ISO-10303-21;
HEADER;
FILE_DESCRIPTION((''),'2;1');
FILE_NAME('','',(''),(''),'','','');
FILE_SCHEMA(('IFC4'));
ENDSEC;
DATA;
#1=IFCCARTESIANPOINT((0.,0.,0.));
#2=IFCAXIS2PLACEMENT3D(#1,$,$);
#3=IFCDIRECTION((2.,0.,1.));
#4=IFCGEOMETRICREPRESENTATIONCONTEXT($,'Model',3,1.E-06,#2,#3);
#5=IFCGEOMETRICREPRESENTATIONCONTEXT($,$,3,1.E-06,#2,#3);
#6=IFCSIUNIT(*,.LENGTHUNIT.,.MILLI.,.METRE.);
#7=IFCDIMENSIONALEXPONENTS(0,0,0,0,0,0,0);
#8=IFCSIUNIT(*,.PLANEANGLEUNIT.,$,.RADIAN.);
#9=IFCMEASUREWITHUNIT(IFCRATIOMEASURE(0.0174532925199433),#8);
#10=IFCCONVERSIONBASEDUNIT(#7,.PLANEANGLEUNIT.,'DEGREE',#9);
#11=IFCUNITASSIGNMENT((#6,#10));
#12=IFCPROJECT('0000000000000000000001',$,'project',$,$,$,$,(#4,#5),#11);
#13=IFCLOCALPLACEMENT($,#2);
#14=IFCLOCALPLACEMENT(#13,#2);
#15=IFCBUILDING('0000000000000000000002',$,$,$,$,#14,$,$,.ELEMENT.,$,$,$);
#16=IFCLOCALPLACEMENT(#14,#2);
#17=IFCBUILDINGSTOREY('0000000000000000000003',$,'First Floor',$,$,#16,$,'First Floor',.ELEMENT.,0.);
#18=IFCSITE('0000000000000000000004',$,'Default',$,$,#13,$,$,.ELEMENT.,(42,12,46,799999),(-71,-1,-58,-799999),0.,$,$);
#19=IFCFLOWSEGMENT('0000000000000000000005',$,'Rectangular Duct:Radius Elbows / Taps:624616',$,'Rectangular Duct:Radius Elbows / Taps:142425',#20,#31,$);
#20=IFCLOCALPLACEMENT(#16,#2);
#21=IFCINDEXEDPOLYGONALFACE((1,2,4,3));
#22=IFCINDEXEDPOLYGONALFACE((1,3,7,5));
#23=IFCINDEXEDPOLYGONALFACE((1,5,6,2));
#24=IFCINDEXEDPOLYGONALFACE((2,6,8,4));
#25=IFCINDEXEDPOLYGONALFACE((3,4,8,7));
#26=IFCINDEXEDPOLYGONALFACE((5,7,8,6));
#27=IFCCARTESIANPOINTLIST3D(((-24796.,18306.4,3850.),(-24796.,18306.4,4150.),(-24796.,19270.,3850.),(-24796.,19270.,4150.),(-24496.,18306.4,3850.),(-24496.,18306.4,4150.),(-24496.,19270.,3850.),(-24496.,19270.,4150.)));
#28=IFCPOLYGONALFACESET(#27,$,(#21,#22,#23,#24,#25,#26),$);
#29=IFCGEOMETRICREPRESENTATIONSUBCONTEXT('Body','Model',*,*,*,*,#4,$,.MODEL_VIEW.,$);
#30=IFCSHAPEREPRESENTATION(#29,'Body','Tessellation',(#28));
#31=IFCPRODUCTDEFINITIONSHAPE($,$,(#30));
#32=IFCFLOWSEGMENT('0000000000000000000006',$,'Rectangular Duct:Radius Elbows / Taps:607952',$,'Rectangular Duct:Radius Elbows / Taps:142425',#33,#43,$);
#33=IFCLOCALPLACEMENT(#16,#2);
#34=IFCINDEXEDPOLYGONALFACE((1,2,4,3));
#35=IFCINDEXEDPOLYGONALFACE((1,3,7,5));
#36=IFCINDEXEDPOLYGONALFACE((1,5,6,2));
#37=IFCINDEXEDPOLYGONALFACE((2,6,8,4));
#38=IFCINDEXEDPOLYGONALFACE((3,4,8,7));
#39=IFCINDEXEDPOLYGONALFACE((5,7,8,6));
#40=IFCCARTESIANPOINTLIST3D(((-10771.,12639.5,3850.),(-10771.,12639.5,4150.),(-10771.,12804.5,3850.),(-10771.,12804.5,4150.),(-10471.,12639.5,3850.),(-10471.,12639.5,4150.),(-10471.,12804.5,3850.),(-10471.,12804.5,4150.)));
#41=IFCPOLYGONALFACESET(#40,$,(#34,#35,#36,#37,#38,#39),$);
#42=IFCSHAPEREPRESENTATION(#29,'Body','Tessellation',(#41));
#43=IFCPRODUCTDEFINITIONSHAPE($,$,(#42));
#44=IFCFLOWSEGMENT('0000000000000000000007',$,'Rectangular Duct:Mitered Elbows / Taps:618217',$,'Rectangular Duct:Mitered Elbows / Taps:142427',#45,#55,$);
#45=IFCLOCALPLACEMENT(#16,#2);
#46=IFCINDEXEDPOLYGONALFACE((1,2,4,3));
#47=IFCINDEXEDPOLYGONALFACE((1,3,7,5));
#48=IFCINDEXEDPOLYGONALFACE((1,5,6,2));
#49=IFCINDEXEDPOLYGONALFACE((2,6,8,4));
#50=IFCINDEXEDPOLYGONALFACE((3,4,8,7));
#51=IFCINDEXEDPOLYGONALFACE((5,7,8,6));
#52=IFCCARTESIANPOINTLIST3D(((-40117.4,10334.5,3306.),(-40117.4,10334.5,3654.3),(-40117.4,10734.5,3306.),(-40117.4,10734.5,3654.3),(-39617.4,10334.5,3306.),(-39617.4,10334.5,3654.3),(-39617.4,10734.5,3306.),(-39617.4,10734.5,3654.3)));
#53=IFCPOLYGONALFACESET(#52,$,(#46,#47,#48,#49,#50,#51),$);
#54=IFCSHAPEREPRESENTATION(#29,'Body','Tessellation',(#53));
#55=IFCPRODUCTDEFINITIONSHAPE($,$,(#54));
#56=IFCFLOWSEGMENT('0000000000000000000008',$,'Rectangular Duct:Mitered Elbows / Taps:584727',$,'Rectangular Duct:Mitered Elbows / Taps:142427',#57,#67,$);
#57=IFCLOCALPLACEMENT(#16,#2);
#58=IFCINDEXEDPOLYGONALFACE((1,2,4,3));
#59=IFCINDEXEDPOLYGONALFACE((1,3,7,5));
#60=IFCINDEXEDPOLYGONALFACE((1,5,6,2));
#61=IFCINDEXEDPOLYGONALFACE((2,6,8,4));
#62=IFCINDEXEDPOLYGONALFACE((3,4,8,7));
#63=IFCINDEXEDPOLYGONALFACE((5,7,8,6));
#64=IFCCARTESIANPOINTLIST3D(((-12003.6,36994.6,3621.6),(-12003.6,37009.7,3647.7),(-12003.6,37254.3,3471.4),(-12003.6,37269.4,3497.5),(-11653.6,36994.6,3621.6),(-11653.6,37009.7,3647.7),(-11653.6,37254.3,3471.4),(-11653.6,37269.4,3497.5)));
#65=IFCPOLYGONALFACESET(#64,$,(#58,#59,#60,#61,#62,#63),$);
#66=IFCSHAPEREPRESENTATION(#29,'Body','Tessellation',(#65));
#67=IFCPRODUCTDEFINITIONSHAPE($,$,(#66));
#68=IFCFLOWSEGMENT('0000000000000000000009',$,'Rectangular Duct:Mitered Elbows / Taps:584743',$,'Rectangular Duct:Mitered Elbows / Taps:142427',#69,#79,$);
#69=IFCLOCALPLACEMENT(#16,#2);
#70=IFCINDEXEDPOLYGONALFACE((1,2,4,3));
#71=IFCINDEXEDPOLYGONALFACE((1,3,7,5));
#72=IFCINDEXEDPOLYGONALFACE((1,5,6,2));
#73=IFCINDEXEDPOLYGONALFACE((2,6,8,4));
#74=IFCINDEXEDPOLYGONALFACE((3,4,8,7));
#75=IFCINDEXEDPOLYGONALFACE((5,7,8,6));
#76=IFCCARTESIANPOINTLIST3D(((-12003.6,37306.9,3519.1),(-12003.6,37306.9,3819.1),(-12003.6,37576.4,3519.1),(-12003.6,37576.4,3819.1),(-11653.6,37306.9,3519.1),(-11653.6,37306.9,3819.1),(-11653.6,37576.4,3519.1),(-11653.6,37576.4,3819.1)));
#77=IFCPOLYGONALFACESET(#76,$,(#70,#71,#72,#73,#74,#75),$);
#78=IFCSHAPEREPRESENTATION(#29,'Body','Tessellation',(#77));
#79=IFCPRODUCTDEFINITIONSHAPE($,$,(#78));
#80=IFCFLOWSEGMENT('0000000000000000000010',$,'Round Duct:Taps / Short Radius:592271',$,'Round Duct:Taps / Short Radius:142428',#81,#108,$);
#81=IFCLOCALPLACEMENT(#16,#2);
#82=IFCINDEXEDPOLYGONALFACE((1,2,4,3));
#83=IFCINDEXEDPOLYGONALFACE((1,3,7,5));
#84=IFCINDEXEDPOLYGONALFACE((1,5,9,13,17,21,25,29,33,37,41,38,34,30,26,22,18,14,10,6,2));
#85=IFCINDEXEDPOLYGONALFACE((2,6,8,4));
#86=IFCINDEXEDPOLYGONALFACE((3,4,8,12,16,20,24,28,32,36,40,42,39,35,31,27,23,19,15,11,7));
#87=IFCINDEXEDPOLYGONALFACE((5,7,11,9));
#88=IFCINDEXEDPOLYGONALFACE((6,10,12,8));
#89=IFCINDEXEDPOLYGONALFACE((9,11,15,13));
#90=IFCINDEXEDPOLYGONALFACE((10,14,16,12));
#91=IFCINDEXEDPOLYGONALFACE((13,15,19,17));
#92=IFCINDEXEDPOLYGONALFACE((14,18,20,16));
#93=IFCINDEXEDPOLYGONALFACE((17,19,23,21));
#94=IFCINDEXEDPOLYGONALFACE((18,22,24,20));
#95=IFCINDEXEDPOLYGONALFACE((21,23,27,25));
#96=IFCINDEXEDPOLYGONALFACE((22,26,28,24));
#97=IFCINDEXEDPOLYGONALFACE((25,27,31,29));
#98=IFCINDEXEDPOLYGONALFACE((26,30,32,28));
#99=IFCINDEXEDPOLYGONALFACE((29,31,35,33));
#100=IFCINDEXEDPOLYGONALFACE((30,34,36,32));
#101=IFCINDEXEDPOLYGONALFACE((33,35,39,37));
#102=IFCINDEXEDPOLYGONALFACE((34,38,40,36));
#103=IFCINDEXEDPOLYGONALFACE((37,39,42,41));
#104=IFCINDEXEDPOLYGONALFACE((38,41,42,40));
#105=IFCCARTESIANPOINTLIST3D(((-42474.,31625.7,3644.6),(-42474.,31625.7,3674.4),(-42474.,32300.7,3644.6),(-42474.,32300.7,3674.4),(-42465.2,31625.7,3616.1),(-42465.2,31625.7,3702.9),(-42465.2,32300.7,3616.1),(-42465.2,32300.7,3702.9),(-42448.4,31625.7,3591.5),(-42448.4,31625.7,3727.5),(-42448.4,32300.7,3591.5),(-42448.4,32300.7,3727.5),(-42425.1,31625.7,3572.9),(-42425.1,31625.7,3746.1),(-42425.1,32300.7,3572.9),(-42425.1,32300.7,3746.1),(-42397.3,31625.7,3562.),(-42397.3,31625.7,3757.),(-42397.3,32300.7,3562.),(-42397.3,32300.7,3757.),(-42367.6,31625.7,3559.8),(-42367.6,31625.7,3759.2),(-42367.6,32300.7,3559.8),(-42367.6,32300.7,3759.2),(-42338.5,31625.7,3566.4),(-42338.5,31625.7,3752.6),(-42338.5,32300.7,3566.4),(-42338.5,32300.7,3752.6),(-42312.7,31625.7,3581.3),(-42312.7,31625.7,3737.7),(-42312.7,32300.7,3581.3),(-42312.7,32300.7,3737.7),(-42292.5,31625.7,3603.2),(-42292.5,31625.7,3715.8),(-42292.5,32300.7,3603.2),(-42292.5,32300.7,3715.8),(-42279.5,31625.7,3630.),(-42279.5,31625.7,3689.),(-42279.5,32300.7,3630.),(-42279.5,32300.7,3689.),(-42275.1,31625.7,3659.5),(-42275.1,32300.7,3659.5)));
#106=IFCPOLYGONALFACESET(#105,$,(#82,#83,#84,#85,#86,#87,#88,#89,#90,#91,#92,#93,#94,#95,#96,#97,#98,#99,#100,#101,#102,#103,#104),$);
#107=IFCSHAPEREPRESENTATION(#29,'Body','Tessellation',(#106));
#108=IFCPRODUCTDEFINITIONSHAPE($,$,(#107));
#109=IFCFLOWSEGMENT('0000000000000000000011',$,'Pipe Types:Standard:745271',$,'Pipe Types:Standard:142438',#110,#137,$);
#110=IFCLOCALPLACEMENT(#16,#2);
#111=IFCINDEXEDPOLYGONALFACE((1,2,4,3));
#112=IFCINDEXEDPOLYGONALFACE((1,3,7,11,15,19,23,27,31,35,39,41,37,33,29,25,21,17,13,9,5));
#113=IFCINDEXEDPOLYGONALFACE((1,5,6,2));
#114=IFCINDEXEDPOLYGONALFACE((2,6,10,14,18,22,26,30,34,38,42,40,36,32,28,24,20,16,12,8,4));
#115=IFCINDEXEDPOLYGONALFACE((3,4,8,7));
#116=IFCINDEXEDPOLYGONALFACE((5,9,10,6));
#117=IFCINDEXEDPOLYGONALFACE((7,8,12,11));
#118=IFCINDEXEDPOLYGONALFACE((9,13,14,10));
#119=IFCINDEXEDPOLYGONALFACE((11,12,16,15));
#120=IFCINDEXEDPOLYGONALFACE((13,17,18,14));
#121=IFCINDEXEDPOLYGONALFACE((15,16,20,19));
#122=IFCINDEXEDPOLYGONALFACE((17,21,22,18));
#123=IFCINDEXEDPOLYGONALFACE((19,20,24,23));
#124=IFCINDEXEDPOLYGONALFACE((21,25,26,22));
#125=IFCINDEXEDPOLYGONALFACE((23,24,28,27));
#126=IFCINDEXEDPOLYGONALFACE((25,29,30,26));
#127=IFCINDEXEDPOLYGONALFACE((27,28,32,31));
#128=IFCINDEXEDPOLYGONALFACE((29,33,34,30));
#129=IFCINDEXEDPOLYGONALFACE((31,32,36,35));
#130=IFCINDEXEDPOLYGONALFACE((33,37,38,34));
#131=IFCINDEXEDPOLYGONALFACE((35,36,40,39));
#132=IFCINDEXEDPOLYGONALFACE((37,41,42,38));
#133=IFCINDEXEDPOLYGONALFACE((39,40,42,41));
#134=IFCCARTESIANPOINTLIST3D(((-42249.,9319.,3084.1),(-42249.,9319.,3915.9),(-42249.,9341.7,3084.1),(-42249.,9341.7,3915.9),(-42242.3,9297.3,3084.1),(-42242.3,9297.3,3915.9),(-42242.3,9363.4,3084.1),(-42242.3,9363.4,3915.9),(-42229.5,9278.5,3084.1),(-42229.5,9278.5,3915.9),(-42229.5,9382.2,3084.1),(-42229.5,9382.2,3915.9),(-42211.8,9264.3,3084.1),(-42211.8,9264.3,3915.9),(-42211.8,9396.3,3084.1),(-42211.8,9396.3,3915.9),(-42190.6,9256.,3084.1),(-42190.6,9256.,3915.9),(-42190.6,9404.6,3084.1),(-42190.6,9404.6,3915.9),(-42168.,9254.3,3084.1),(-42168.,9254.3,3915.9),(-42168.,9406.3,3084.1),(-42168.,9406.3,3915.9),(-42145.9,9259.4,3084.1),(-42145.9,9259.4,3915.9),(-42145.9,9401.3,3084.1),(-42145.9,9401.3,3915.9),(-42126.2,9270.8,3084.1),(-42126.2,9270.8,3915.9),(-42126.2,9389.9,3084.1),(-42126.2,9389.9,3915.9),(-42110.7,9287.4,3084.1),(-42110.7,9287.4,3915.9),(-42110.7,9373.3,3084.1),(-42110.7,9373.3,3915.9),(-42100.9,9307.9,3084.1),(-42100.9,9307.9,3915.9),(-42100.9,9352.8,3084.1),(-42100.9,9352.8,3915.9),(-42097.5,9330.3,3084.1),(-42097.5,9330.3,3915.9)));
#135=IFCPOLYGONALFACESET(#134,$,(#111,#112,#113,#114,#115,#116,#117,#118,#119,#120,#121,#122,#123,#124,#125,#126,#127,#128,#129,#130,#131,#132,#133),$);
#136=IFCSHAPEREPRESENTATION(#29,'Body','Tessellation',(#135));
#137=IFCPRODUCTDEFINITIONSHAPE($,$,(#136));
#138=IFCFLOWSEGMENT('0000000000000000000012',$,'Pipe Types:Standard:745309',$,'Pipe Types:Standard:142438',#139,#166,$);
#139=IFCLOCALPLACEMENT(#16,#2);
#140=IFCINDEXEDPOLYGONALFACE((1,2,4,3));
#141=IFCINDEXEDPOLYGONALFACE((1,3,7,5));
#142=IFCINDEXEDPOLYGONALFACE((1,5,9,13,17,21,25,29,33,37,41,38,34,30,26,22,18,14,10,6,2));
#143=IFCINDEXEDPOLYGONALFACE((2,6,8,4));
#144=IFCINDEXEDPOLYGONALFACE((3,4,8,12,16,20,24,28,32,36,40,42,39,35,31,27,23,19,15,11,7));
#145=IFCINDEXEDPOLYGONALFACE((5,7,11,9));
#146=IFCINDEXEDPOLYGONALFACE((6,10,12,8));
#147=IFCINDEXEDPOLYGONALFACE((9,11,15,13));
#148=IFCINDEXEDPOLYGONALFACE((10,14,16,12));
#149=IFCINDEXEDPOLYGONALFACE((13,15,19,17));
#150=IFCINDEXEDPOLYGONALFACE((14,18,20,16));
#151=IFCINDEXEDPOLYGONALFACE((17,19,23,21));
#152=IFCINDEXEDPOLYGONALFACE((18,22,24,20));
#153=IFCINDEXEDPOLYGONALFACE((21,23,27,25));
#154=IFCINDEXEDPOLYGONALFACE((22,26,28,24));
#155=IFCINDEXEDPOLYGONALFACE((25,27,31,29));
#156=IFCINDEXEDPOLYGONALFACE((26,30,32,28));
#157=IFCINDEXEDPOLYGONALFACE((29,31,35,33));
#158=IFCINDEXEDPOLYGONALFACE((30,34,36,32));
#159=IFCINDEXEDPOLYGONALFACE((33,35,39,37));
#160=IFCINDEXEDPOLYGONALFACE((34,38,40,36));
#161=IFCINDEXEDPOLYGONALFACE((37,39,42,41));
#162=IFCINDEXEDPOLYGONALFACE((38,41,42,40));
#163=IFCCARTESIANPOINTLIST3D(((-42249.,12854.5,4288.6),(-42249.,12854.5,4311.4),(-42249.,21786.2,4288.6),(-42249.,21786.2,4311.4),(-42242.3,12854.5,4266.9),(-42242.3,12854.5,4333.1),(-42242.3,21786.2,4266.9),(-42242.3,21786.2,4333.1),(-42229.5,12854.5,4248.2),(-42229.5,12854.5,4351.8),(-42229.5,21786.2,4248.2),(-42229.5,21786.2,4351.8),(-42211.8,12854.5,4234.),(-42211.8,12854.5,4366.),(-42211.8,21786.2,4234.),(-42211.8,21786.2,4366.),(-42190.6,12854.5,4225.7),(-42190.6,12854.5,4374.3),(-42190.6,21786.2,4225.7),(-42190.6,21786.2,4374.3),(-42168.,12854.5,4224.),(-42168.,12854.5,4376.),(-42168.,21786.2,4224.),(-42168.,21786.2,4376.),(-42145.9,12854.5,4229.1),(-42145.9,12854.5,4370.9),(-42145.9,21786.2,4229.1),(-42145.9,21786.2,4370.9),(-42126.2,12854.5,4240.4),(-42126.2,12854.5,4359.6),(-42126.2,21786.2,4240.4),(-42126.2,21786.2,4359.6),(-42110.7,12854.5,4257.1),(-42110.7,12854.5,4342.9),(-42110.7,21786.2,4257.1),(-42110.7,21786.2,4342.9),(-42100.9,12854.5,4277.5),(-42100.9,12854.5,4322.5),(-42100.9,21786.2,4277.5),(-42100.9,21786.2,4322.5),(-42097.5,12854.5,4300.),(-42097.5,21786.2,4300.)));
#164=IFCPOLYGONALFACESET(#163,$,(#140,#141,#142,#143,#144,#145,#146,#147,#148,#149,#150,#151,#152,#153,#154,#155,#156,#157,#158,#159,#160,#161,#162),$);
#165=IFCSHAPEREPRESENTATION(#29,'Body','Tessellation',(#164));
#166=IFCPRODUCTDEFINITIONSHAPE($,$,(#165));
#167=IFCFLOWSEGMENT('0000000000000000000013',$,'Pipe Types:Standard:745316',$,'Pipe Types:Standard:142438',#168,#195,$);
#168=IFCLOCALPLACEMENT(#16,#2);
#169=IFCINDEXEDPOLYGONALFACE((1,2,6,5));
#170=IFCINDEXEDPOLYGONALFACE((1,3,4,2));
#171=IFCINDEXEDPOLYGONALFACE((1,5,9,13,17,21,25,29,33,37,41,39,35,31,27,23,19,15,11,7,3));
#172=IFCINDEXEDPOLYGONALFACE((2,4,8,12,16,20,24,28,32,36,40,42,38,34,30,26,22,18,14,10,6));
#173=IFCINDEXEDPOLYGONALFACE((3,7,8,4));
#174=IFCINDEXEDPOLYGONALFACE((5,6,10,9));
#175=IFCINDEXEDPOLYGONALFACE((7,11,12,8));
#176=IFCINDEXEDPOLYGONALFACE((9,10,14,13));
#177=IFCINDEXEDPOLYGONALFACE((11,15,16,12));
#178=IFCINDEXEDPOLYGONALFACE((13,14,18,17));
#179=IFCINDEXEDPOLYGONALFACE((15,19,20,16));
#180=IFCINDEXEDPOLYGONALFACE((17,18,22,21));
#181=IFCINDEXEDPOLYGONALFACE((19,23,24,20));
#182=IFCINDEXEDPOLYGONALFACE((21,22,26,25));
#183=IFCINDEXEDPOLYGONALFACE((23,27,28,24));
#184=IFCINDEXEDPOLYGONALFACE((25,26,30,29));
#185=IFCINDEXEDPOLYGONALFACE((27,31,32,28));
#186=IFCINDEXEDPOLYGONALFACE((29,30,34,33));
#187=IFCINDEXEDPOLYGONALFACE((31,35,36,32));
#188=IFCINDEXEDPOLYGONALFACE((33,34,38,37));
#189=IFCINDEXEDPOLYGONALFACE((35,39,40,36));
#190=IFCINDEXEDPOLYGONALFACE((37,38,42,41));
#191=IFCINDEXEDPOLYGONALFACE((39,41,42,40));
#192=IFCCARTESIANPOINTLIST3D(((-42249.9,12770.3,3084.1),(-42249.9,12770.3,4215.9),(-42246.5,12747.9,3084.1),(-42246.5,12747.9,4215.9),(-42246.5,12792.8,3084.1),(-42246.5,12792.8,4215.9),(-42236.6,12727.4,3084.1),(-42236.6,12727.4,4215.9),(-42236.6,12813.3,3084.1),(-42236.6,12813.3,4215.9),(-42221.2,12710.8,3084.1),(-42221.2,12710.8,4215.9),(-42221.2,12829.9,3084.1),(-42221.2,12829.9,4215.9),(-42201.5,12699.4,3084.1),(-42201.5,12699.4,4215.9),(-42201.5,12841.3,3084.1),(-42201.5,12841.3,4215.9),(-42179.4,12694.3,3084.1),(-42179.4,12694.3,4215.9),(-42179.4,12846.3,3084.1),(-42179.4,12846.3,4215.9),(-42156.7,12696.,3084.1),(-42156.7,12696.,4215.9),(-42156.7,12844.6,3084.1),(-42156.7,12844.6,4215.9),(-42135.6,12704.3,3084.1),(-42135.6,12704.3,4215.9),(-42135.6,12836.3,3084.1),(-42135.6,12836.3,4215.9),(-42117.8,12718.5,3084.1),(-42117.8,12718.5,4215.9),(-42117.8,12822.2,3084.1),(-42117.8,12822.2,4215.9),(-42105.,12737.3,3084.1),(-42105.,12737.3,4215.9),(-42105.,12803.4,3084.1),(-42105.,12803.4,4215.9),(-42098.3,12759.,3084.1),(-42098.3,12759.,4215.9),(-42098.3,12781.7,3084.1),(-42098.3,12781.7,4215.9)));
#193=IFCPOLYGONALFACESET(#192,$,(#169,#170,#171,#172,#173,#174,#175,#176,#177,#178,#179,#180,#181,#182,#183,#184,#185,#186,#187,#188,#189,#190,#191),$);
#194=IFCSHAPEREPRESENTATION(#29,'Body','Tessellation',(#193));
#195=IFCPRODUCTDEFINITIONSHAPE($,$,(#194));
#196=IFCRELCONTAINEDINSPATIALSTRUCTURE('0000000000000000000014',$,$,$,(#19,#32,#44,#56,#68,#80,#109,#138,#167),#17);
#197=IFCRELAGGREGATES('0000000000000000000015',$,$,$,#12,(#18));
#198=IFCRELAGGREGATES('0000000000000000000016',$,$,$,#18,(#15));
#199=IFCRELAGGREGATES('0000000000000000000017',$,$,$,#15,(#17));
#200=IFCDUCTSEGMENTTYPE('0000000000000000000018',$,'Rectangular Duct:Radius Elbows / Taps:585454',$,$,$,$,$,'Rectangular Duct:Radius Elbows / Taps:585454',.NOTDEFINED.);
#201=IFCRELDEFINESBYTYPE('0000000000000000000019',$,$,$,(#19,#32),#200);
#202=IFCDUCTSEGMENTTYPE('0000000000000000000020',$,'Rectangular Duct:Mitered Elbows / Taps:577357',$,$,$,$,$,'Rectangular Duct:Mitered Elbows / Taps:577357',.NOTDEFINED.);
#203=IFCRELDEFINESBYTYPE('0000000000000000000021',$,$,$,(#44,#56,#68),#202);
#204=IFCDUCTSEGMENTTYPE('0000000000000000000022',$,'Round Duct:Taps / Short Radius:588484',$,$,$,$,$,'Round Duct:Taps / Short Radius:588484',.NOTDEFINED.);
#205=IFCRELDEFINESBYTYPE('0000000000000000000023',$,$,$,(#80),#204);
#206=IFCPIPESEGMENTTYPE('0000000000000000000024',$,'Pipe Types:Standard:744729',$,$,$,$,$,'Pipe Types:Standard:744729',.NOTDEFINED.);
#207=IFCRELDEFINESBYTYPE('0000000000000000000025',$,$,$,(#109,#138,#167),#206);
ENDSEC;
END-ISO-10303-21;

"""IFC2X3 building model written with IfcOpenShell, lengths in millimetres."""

from ifc_helpers import new_model, entity, si_unit, converted_unit, direction, frame, frame_2d, origin, origin_2d_with_axis, place, context, subcontext, project, spatial, rectangle, circle, extrude, type_object, element, save


model = new_model("IFC2X3")

# Units and contexts
model_context = context("Model", 3, precision=1e-06, world=origin(), true_north=direction((2.0, 0.0, 1.0)))
context_of_model = context(None, 3, precision=1e-06, world=origin(), true_north=direction((2.0, 0.0, 1.0)))
body_context = subcontext(model_context, "Body", "Model", "MODEL_VIEW")
ifc_project = project(units=[si_unit("LENGTHUNIT", "METRE", prefix="MILLI"), converted_unit("PLANEANGLEUNIT", "DEGREE", entity("IfcRatioMeasure", 0.0174532925199433), si_unit("PLANEANGLEUNIT", "RADIAN"), dimensions=[0, 0, 0, 0, 0, 0, 0])], contexts=[model_context, context_of_model])

# Site, building, storey
site_placement = place(None, origin())
site = spatial("IfcSite", under=ifc_project, at=site_placement, Name="Default", CompositionType="ELEMENT", RefLatitude=(42, 12, 46, 799999), RefLongitude=(-71, -1, -58, -799999), RefElevation=0.0)
building_placement = place(site_placement, origin())
building = spatial("IfcBuilding", under=site, at=building_placement, CompositionType="ELEMENT")
storey_placement = place(building_placement, origin())
storey = spatial("IfcBuildingStorey", under=building, at=storey_placement, Name="First Floor", LongName="First Floor", CompositionType="ELEMENT", Elevation=0.0)

# Flow segments
duct_segment_type_1 = type_object("IfcDuctSegmentType", Name="Rectangular Duct:Radius Elbows / Taps:585454", ElementType="Rectangular Duct:Radius Elbows / Taps:585454", PredefinedType="NOTDEFINED")
flow_segment_1_placement = place(storey_placement, origin())
element("IfcFlowSegment", 1, at=flow_segment_1_placement, inside=storey, type_object=duct_segment_type_1, Name="Rectangular Duct:Radius Elbows / Taps:624616", ObjectType="Rectangular Duct:Radius Elbows / Taps:142425", context=body_context, shape_type="SweptSolid", body=[
    extrude(rectangle(XDim=963.6, YDim=300.0, at=origin_2d_with_axis()), frame((-24646.0, 18788.2, 3850.0), z_axis=(0.0, 0.0, 1.0), x_axis=(0.0, 1.0, 0.0)), (0.0, 0.0, 1.0), 300.0),
])
flow_segment_2_placement = place(storey_placement, origin())
element("IfcFlowSegment", 2, at=flow_segment_2_placement, inside=storey, type_object=duct_segment_type_1, Name="Rectangular Duct:Radius Elbows / Taps:607952", ObjectType="Rectangular Duct:Radius Elbows / Taps:142425", context=body_context, shape_type="SweptSolid", body=[
    extrude(rectangle(XDim=165.0, YDim=300.0, at=frame_2d((0.0, 0.0), x_axis=(1.0, 0.0))), frame((-10621.0, 12722.0, 3850.0), z_axis=(0.0, 0.0, 1.0), x_axis=(0.0, -1.0, 0.0)), (0.0, 0.0, 1.0), 300.0),
])
duct_segment_type_2 = type_object("IfcDuctSegmentType", Name="Rectangular Duct:Mitered Elbows / Taps:577357", ElementType="Rectangular Duct:Mitered Elbows / Taps:577357", PredefinedType="NOTDEFINED")
flow_segment_3_placement = place(storey_placement, origin())
element("IfcFlowSegment", 3, at=flow_segment_3_placement, inside=storey, type_object=duct_segment_type_2, Name="Rectangular Duct:Mitered Elbows / Taps:618217", ObjectType="Rectangular Duct:Mitered Elbows / Taps:142427", context=body_context, shape_type="SweptSolid", body=[
    extrude(rectangle(XDim=500.0, YDim=400.0, at=origin_2d_with_axis()), frame((-39867.4, 10534.5, 3306.0)), (0.0, 0.0, 1.0), 348.3),
])
flow_segment_4_placement = place(storey_placement, origin())
element("IfcFlowSegment", 4, at=flow_segment_4_placement, inside=storey, type_object=duct_segment_type_2, Name="Rectangular Duct:Mitered Elbows / Taps:584727", ObjectType="Rectangular Duct:Mitered Elbows / Taps:142427", context=body_context, shape_type="SweptSolid", body=[
    extrude(rectangle(XDim=30.1, YDim=300.0, at=frame_2d((0.0, 0.0), x_axis=(1.0, 0.0))), frame((-12003.6, 37132.0, 3559.6), z_axis=(1.0, 0.0, 0.0), x_axis=(0.0, -0.500814, -0.865555)), (0.0, 0.0, 1.0), 350.0),
])
flow_segment_5_placement = place(storey_placement, origin())
element("IfcFlowSegment", 5, at=flow_segment_5_placement, inside=storey, type_object=duct_segment_type_2, Name="Rectangular Duct:Mitered Elbows / Taps:584743", ObjectType="Rectangular Duct:Mitered Elbows / Taps:142427", context=body_context, shape_type="SweptSolid", body=[
    extrude(rectangle(XDim=269.5, YDim=350.0, at=frame_2d((0.0, 0.0), x_axis=(1.0, 0.0))), frame((-11828.6, 37441.6, 3519.1), z_axis=(0.0, 0.0, 1.0), x_axis=(0.0, -1.0, 0.0)), (0.0, 0.0, 1.0), 300.0),
])
duct_segment_type_3 = type_object("IfcDuctSegmentType", Name="Round Duct:Taps / Short Radius:588484", ElementType="Round Duct:Taps / Short Radius:588484", PredefinedType="NOTDEFINED")
flow_segment_6_placement = place(storey_placement, origin())
element("IfcFlowSegment", 6, at=flow_segment_6_placement, inside=storey, type_object=duct_segment_type_3, Name="Round Duct:Taps / Short Radius:592271", ObjectType="Round Duct:Taps / Short Radius:142428", context=body_context, shape_type="SweptSolid", body=[
    extrude(circle(Radius=100.0, at=origin_2d_with_axis()), frame((-42375.1, 31625.7, 3659.5), z_axis=(0.0, 1.0, 0.0), x_axis=(1.0, 0.0, 0.0)), (0.0, 0.0, 1.0), 675.0),
])
pipe_segment_type = type_object("IfcPipeSegmentType", Name="Pipe Types:Standard:744729", ElementType="Pipe Types:Standard:744729", PredefinedType="NOTDEFINED")
flow_segment_7_placement = place(storey_placement, origin())
element("IfcFlowSegment", 7, at=flow_segment_7_placement, inside=storey, type_object=pipe_segment_type, Name="Pipe Types:Standard:745271", ObjectType="Pipe Types:Standard:142438", context=body_context, shape_type="SweptSolid", body=[
    extrude(circle(Radius=76.2, at=origin_2d_with_axis()), frame((-42173.7, 9330.3, 3084.1)), (0.0, 0.0, 1.0), 831.7),
])
flow_segment_8_placement = place(storey_placement, origin())
element("IfcFlowSegment", 8, at=flow_segment_8_placement, inside=storey, type_object=pipe_segment_type, Name="Pipe Types:Standard:745309", ObjectType="Pipe Types:Standard:142438", context=body_context, shape_type="SweptSolid", body=[
    extrude(circle(Radius=76.2, at=origin_2d_with_axis()), frame((-42173.7, 12854.5, 4300.0), z_axis=(0.0, 1.0, 0.0), x_axis=(1.0, 0.0, 0.0)), (0.0, 0.0, 1.0), 8931.7),
])
flow_segment_9_placement = place(storey_placement, origin())
element("IfcFlowSegment", 9, at=flow_segment_9_placement, inside=storey, type_object=pipe_segment_type, Name="Pipe Types:Standard:745316", ObjectType="Pipe Types:Standard:142438", context=body_context, shape_type="SweptSolid", body=[
    extrude(circle(Radius=76.2, at=origin_2d_with_axis()), frame((-42173.7, 12770.3, 3084.1), z_axis=(0.0, 0.0, 1.0), x_axis=(-1.0, 0.0, 0.0)), (0.0, 0.0, 1.0), 1131.7),
])

save(model, "model.ifc")
